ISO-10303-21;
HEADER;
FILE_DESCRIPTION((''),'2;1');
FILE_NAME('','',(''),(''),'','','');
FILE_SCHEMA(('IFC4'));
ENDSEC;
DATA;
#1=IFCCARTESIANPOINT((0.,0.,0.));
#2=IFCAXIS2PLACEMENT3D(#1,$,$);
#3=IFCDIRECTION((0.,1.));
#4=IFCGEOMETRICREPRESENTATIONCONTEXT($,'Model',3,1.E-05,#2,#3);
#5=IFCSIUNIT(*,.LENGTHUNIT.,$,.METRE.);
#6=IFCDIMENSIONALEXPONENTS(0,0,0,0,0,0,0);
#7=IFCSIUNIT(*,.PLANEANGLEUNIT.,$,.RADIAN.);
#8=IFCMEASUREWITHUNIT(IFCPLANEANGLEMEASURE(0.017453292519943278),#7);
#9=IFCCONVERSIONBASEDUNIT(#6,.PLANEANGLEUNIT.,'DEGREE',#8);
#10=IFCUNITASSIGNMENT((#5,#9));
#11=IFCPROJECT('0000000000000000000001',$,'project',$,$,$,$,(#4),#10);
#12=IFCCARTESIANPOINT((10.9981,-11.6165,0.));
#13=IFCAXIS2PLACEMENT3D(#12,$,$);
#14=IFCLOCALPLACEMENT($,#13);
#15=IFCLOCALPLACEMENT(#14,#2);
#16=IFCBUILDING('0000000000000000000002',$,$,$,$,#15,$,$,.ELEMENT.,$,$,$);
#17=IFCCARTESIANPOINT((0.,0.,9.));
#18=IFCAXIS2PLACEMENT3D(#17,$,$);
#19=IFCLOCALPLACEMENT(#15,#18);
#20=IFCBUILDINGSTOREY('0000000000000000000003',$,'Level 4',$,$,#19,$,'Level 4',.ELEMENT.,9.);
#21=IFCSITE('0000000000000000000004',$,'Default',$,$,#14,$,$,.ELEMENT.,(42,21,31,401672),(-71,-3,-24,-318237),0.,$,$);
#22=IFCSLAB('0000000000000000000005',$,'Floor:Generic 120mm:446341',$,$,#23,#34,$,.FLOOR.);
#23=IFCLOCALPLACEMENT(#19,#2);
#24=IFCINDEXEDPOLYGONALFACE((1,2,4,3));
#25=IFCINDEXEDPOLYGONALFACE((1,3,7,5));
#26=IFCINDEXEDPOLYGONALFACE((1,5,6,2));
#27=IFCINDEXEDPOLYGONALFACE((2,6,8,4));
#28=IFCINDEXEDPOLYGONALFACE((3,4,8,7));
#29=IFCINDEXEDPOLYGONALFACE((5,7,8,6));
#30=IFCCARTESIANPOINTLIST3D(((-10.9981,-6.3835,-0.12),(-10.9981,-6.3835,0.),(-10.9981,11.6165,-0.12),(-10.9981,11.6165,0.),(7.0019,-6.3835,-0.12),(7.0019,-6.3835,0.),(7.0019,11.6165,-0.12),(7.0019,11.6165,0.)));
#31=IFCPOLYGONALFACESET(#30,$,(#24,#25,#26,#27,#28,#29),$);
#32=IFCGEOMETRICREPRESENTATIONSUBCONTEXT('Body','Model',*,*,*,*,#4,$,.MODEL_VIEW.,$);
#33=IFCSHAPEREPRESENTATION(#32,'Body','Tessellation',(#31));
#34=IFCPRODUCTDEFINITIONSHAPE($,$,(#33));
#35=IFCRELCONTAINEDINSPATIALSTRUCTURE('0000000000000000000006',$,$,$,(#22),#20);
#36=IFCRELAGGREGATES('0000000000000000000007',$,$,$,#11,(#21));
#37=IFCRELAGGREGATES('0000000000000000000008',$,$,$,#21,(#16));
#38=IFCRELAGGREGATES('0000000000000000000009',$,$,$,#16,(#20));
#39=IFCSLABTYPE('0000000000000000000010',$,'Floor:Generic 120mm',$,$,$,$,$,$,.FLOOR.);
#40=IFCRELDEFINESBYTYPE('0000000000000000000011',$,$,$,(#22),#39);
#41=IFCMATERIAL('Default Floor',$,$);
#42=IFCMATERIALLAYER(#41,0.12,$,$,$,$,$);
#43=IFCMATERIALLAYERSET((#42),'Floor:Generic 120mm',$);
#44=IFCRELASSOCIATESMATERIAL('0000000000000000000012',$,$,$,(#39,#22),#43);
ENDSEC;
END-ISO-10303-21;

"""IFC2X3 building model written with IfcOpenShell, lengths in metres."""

from ifc_helpers import new_model, entity, si_unit, converted_unit, direction, frame, origin, origin_2d_with_axis, place, context, subcontext, project, spatial, rectangle, extrude, material, layer, layer_set, layer_usage, type_object, element, save


model = new_model("IFC2X3")

# Units and contexts
model_context = context("Model", 3, precision=1e-05, world=origin(), true_north=direction((0.0, 1.0)))
body_context = subcontext(model_context, "Body", "Model", "MODEL_VIEW")
ifc_project = project(units=[si_unit("LENGTHUNIT", "METRE"), converted_unit("PLANEANGLEUNIT", "DEGREE", entity("IfcPlaneAngleMeasure", 0.017453292519943278), si_unit("PLANEANGLEUNIT", "RADIAN"), dimensions=[0, 0, 0, 0, 0, 0, 0])], contexts=[model_context])

# Site, building, storey
site_placement = place(None, frame((10.9981, -11.6165, 0.0)))
site = spatial("IfcSite", under=ifc_project, at=site_placement, Name="Default", CompositionType="ELEMENT", RefLatitude=(42, 21, 31, 401672), RefLongitude=(-71, -3, -24, -318237), RefElevation=0.0)
building_placement = place(site_placement, origin())
building = spatial("IfcBuilding", under=site, at=building_placement, CompositionType="ELEMENT")
storey_placement = place(building_placement, frame((0.0, 0.0, 9.0)))
storey = spatial("IfcBuildingStorey", under=building, at=storey_placement, Name="Level 4", LongName="Level 4", CompositionType="ELEMENT", Elevation=9.0)

# Slab
ifc_material_1 = material(Name="Default Floor")
ifc_layer = layer(ifc_material_1, 0.12)
ifc_layer_set = layer_set([ifc_layer], Name="Floor:Generic 120mm")
ifc_layer_usage = layer_usage(ifc_layer_set, "AXIS3", "POSITIVE", 0.0)
slab_type = type_object("IfcSlabType", Name="Floor:Generic 120mm", PredefinedType="FLOOR", material=ifc_layer_set)
slab_placement = place(storey_placement, origin())
element("IfcSlab", 1, at=slab_placement, inside=storey, type_object=slab_type, material=ifc_layer_usage, Name="Floor:Generic 120mm:446341", PredefinedType="FLOOR", context=body_context, shape_type="SweptSolid", body=[
    extrude(rectangle(XDim=18.0, YDim=18.0, at=origin_2d_with_axis()), frame((-1.9981, 2.6165, 0.0), z_axis=(0.0, 0.0, -1.0), x_axis=(0.0, 1.0, 0.0)), (0.0, 0.0, 1.0), 0.12),
])

save(model, "model.ifc")
